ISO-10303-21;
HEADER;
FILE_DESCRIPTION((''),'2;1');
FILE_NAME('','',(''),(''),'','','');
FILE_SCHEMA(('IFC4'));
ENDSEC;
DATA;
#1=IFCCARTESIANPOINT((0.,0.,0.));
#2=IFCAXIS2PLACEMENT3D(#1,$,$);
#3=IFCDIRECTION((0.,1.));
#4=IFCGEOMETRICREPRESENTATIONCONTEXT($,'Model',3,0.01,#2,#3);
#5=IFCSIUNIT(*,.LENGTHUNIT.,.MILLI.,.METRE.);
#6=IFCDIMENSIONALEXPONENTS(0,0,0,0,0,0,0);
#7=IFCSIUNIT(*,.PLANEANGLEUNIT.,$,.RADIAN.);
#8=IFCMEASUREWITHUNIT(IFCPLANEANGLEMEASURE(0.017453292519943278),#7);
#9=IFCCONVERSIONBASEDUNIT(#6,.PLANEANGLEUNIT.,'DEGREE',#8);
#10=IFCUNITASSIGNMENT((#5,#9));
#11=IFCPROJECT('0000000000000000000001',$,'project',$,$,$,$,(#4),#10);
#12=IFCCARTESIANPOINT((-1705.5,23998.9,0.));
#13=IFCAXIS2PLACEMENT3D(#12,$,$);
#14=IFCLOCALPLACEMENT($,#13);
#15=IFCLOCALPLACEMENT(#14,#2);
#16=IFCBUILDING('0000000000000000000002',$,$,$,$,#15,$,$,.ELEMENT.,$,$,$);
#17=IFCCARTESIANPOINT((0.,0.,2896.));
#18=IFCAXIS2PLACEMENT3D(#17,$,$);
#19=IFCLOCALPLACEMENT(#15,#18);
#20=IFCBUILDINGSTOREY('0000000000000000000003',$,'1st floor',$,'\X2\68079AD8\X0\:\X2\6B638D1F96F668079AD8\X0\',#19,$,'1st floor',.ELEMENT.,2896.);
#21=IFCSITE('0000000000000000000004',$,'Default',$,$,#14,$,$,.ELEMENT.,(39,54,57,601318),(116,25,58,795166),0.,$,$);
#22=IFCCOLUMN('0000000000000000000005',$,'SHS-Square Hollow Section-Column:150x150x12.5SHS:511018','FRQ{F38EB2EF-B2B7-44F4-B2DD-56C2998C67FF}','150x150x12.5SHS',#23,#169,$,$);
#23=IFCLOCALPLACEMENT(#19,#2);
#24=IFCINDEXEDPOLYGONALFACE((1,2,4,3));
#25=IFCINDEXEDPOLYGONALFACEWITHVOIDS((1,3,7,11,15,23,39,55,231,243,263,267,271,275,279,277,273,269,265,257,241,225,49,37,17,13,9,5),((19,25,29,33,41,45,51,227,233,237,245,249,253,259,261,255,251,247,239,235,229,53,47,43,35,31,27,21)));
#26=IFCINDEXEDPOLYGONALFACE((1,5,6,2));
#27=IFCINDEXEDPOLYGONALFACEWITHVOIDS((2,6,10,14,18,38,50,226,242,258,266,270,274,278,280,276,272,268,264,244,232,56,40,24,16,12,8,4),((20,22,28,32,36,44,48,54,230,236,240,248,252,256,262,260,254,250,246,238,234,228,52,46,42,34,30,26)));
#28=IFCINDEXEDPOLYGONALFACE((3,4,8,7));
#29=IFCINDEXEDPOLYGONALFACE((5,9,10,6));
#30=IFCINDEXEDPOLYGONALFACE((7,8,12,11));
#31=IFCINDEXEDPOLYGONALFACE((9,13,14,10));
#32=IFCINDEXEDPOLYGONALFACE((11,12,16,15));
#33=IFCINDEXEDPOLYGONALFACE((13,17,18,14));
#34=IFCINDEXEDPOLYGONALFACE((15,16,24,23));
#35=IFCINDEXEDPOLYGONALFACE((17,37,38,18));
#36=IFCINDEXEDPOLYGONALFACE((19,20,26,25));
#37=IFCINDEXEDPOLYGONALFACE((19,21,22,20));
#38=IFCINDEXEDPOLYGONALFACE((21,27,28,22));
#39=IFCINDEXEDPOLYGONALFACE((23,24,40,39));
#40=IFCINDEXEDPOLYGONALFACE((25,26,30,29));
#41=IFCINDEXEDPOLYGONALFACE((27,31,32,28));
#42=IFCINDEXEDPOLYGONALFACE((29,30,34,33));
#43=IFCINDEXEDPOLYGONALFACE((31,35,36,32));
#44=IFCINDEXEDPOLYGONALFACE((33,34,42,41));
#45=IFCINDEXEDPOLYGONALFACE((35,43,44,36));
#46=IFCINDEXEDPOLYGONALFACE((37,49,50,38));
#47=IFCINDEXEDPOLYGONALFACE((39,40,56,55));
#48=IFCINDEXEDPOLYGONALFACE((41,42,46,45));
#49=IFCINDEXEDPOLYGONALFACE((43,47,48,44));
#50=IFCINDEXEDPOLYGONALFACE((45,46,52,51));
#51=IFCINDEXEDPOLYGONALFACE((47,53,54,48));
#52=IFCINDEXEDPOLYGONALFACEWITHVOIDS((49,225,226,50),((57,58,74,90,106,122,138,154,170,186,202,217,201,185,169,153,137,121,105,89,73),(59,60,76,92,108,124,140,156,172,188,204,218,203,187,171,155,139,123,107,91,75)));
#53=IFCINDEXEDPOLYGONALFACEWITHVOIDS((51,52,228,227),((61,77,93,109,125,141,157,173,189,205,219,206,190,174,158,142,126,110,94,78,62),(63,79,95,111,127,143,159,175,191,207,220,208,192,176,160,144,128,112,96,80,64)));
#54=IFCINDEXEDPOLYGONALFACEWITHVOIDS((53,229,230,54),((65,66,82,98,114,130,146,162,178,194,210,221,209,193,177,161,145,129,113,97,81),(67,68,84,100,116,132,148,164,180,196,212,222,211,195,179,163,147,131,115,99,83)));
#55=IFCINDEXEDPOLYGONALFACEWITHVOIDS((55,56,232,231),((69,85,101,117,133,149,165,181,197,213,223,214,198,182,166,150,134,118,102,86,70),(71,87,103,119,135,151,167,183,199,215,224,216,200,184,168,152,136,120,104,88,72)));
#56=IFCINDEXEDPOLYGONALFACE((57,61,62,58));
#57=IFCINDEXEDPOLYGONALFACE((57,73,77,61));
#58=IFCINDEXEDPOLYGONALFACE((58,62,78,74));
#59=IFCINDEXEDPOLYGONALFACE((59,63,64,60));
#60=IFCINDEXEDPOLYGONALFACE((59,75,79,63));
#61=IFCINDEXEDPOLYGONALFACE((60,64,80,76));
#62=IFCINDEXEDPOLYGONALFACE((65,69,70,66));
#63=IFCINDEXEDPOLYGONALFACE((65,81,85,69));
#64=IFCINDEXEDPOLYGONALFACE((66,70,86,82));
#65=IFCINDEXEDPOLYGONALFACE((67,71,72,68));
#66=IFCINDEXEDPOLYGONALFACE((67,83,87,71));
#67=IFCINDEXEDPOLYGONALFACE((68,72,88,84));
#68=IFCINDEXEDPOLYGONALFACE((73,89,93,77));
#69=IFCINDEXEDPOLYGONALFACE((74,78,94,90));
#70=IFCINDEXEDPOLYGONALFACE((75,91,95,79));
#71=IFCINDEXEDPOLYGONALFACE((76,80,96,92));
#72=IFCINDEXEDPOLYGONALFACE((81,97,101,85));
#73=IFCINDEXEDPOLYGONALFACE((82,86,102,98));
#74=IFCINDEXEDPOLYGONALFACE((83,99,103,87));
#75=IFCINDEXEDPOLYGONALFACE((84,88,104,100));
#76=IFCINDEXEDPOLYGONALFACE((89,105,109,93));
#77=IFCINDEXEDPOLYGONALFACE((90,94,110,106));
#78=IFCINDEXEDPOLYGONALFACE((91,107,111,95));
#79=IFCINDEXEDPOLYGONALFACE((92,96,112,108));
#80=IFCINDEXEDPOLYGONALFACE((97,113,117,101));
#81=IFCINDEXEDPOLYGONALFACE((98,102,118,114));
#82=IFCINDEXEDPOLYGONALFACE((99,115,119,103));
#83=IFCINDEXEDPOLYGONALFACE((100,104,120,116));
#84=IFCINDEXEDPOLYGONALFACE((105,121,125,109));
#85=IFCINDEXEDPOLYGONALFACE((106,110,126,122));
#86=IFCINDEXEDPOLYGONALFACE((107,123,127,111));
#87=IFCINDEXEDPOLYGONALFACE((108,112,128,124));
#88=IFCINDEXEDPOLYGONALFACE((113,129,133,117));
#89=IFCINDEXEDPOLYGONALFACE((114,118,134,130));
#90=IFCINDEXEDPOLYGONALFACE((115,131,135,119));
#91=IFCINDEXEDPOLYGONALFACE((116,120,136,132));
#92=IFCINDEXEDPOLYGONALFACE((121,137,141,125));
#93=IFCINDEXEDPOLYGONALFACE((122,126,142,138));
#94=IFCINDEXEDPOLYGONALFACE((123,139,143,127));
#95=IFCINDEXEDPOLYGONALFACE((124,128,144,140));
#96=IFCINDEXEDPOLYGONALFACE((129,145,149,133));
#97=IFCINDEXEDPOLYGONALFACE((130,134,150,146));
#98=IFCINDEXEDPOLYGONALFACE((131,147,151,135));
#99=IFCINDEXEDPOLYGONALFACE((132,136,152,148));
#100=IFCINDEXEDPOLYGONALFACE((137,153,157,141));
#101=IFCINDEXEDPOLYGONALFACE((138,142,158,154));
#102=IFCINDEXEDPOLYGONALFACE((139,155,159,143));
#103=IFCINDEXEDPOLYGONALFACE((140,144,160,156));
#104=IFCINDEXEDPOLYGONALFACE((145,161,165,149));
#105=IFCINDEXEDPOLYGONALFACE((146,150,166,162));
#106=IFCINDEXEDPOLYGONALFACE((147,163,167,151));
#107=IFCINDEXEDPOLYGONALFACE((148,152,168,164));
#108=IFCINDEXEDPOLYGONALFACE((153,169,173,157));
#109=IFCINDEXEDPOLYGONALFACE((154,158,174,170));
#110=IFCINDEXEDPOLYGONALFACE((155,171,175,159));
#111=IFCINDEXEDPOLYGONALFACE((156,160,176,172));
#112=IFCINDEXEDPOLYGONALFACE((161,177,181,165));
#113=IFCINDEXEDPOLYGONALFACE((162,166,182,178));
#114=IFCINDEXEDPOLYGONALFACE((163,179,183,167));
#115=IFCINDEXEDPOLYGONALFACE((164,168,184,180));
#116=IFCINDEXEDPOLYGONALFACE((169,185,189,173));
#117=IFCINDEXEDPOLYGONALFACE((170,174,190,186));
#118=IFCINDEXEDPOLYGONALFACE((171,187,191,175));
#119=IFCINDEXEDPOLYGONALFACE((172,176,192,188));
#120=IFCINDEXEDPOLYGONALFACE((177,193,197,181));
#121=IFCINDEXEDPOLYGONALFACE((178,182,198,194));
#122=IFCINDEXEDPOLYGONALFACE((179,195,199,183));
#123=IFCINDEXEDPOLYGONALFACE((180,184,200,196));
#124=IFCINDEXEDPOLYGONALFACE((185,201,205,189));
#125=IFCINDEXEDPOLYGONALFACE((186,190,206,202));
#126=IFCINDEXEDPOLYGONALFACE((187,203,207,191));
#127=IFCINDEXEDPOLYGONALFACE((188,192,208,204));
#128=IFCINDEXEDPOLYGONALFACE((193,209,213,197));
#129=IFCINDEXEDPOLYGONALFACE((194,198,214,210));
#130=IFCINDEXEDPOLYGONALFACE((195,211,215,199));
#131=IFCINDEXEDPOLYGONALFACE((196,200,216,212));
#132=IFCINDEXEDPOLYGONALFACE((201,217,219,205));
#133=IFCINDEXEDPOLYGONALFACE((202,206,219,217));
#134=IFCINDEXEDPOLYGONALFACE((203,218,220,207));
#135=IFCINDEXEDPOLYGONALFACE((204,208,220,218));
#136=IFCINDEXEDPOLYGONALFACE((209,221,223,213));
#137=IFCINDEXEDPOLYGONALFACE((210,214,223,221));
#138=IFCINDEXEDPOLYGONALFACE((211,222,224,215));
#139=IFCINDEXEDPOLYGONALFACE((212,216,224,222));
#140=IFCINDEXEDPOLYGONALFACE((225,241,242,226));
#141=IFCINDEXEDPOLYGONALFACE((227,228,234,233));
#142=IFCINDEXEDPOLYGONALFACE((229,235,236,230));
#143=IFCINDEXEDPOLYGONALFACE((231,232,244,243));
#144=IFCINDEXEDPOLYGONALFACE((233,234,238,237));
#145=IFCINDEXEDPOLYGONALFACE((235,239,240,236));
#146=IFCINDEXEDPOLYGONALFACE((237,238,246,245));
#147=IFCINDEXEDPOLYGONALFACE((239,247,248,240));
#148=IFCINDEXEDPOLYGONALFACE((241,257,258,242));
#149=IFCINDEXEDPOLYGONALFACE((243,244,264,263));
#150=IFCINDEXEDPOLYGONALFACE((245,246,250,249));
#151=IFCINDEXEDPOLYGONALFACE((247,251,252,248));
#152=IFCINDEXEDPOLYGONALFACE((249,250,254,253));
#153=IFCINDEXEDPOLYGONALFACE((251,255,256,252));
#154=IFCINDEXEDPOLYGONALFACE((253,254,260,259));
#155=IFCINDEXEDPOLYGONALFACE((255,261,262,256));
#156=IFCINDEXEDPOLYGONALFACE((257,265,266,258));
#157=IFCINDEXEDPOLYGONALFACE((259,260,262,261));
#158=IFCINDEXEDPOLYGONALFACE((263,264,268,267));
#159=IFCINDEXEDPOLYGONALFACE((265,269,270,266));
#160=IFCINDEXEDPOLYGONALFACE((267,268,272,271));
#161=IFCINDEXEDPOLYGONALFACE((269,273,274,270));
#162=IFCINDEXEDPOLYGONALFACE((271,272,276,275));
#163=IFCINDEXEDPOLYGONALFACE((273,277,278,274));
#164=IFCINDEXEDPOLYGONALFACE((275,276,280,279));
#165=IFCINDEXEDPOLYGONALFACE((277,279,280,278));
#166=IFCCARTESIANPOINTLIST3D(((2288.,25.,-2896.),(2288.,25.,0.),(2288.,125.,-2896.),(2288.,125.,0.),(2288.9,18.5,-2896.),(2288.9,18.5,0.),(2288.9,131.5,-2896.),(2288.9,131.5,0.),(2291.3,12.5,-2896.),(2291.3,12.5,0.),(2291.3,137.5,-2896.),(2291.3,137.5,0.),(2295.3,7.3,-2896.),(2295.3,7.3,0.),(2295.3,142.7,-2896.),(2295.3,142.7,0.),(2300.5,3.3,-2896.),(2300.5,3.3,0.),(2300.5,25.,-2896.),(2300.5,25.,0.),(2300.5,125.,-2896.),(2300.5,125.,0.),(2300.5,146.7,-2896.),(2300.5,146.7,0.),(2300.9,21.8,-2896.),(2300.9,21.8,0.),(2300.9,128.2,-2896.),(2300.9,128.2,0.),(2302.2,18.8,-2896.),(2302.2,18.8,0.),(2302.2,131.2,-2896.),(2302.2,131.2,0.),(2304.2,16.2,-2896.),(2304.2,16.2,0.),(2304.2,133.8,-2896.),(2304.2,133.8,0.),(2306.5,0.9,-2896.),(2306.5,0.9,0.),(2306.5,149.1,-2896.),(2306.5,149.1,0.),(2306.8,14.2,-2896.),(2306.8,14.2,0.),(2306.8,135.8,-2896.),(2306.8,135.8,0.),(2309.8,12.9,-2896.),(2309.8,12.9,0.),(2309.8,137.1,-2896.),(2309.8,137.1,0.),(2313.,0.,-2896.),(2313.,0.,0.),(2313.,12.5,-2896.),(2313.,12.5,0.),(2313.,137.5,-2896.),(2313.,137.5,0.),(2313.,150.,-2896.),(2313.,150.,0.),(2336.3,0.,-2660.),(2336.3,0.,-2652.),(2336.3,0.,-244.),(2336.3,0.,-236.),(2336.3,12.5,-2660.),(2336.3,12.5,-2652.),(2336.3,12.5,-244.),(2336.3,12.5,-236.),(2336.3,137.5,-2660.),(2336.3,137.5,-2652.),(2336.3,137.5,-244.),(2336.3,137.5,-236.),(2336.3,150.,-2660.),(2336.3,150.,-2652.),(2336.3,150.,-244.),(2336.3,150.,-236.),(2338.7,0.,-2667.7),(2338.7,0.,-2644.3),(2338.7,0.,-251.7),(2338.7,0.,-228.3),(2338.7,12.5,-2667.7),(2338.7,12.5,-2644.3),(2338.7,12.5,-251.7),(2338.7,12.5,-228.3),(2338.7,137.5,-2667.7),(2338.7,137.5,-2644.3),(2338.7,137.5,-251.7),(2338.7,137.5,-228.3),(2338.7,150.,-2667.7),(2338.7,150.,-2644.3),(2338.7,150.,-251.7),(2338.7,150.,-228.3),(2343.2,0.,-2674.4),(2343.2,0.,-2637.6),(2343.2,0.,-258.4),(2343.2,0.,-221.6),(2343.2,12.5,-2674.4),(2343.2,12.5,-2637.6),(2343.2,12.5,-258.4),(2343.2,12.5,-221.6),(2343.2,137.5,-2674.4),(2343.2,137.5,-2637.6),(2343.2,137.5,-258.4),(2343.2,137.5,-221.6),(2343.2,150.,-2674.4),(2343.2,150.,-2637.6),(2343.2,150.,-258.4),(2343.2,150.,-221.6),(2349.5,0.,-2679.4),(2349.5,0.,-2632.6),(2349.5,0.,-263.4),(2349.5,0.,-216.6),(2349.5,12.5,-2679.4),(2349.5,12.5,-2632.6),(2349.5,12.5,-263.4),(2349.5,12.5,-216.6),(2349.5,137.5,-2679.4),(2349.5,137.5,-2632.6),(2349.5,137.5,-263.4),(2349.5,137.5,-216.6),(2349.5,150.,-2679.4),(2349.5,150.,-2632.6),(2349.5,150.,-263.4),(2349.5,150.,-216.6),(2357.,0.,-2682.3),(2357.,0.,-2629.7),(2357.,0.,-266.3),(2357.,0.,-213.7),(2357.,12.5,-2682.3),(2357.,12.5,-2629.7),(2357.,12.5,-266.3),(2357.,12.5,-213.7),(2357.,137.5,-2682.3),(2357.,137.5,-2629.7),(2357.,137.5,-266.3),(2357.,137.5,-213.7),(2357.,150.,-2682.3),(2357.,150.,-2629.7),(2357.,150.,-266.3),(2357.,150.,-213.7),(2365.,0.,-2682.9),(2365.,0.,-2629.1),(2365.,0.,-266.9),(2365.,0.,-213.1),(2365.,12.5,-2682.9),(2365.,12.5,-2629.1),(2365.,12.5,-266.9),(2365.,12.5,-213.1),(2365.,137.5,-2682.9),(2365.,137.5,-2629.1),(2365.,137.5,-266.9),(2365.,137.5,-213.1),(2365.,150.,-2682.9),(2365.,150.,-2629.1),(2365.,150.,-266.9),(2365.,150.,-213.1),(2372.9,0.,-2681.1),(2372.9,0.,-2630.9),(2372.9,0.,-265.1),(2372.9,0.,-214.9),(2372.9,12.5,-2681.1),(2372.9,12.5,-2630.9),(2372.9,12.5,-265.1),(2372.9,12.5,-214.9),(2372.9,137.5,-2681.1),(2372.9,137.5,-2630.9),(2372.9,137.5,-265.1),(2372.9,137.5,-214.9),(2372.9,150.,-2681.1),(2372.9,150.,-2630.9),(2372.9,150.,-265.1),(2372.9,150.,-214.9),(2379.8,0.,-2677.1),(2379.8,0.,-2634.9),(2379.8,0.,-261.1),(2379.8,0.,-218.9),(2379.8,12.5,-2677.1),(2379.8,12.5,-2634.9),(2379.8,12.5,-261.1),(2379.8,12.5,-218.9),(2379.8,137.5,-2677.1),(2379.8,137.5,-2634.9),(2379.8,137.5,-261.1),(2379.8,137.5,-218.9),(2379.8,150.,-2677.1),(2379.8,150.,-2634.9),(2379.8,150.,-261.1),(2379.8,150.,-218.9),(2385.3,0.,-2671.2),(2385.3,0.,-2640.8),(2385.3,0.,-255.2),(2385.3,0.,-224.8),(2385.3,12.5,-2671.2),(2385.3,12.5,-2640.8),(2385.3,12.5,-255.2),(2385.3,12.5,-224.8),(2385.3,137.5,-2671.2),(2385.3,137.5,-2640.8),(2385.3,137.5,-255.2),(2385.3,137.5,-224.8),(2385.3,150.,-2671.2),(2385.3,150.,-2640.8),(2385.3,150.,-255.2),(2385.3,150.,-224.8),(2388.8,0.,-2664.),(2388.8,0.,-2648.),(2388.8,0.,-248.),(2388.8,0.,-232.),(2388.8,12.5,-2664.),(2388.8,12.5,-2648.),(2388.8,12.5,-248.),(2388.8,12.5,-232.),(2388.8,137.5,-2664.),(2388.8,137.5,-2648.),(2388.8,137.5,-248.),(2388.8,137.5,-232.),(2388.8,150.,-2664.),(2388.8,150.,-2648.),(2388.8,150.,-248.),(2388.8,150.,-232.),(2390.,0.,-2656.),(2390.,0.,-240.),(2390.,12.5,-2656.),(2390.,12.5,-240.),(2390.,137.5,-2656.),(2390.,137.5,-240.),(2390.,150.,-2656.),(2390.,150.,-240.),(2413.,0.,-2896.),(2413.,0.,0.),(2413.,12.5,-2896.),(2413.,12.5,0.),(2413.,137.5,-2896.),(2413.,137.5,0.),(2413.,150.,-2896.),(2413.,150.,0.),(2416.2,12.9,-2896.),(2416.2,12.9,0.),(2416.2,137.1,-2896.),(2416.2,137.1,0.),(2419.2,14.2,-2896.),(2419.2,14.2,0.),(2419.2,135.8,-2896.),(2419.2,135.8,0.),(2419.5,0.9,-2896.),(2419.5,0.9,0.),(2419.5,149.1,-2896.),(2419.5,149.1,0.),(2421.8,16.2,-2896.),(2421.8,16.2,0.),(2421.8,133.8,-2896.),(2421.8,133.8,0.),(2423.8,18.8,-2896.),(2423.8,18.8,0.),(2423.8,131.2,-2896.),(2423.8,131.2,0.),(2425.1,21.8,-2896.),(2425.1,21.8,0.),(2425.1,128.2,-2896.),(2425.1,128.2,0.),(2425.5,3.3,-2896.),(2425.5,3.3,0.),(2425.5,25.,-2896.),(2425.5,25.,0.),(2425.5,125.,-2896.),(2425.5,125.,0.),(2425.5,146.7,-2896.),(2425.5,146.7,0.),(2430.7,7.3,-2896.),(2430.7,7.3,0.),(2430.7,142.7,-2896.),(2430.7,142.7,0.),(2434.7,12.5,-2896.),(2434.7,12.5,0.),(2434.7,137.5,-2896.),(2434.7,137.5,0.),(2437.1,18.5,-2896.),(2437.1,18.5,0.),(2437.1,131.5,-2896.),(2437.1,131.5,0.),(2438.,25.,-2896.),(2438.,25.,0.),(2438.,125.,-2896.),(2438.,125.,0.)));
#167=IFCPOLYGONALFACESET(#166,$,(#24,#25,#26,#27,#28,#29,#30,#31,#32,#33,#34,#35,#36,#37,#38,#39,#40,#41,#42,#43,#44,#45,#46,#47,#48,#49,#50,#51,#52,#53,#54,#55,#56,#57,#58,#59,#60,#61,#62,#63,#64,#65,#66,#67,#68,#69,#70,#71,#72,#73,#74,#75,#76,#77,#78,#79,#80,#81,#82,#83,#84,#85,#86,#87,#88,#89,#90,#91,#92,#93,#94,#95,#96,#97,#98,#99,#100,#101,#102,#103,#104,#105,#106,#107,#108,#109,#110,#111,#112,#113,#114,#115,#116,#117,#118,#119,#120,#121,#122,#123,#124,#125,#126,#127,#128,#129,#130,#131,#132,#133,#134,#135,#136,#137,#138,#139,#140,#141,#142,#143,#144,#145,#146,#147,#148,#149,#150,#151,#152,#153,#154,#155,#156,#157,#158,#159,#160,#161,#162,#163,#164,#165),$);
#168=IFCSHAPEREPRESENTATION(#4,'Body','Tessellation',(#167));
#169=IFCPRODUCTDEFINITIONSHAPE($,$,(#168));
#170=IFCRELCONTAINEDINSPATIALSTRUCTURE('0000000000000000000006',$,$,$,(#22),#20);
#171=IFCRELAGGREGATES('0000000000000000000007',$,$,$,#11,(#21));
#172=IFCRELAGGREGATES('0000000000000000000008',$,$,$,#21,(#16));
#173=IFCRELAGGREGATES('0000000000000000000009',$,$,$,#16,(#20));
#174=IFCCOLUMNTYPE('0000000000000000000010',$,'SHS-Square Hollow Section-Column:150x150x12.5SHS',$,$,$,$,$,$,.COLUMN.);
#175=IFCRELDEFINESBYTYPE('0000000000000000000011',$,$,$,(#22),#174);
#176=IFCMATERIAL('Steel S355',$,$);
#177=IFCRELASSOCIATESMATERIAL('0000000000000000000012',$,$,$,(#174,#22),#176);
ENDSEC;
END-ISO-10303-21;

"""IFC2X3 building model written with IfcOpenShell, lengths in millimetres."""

from ifc_helpers import new_model, entity, si_unit, converted_unit, direction, frame, frame_2d, origin, origin_2d, place, context, project, spatial, circle_curve, hollow_rectangle, outline, extrude, material, type_object, element, save


model = new_model("IFC2X3")

# Units and contexts
model_context = context("Model", 3, precision=0.01, world=origin(), true_north=direction((0.0, 1.0)))
ifc_project = project(units=[si_unit("LENGTHUNIT", "METRE", prefix="MILLI"), converted_unit("PLANEANGLEUNIT", "DEGREE", entity("IfcPlaneAngleMeasure", 0.017453292519943278), si_unit("PLANEANGLEUNIT", "RADIAN"), dimensions=[0, 0, 0, 0, 0, 0, 0])], contexts=[model_context])

# Site, building, storey
site_placement = place(None, frame((-1705.5, 23998.9, 0.0)))
site = spatial("IfcSite", under=ifc_project, at=site_placement, Name="Default", CompositionType="ELEMENT", RefLatitude=(39, 54, 57, 601318), RefLongitude=(116, 25, 58, 795166), RefElevation=0.0)
building_placement = place(site_placement, origin())
building = spatial("IfcBuilding", under=site, at=building_placement, CompositionType="ELEMENT")
storey_placement = place(building_placement, frame((0.0, 0.0, 2896.0)))
storey = spatial("IfcBuildingStorey", under=building, at=storey_placement, Name="1st floor", ObjectType="标高:正负零标高", LongName="1st floor", CompositionType="ELEMENT", Elevation=2896.0)

# Column, openings
ifc_material_1 = material(Name="Steel S355")
column_type_1 = type_object("IfcColumnType", Name="SHS-Square Hollow Section-Column:150x150x12.5SHS", PredefinedType="COLUMN", material=ifc_material_1)
column_1_placement = place(storey_placement, frame((2363.0, 75.0, 0.0), z_axis=(0.0, 0.0, 1.0), x_axis=(0.0, -1.0, 0.0)))
column_1 = element("IfcColumn", 1, at=column_1_placement, inside=storey, type_object=column_type_1, material=ifc_material_1, Name="SHS-Square Hollow Section-Column:150x150x12.5SHS:511018", Description="FRQ{F38EB2EF-B2B7-44F4-B2DD-56C2998C67FF}", ObjectType="150x150x12.5SHS", context=model_context, shape_type="SweptSolid", body=[
    extrude(hollow_rectangle(XDim=150.0, YDim=150.0, WallThickness=12.5, InnerFilletRadius=12.5, OuterFilletRadius=25.0, at=origin_2d()), origin(), (0.0, 0.0, -1.0), 2896.0),
])
opening_1_placement = place(column_1_placement, frame((-175.1, 0.0, 0.0), z_axis=(1.0, 0.0, 0.0), x_axis=(0.0, 1.0, 0.0)))
element("IfcOpeningElement", 2, at=opening_1_placement, cuts=column_1, ObjectType="Opening", context=model_context, shape_type="SweptSolid", body=[
    extrude(outline(circle_curve(frame_2d((0.0, -240.0), x_axis=(1.0, 0.0)), 27.0)), origin(), (0.0, 0.0, 1.0), 350.2),
])
opening_2_placement = place(column_1_placement, frame((-175.1, 0.0, -2896.0), z_axis=(1.0, 0.0, 0.0), x_axis=(0.0, 1.0, 0.0)))
element("IfcOpeningElement", 3, at=opening_2_placement, cuts=column_1, ObjectType="Opening", context=model_context, shape_type="SweptSolid", body=[
    extrude(outline(circle_curve(frame_2d((0.0, 240.0), x_axis=(1.0, 0.0)), 27.0)), origin(), (0.0, 0.0, 1.0), 350.2),
])

save(model, "model.ifc")
